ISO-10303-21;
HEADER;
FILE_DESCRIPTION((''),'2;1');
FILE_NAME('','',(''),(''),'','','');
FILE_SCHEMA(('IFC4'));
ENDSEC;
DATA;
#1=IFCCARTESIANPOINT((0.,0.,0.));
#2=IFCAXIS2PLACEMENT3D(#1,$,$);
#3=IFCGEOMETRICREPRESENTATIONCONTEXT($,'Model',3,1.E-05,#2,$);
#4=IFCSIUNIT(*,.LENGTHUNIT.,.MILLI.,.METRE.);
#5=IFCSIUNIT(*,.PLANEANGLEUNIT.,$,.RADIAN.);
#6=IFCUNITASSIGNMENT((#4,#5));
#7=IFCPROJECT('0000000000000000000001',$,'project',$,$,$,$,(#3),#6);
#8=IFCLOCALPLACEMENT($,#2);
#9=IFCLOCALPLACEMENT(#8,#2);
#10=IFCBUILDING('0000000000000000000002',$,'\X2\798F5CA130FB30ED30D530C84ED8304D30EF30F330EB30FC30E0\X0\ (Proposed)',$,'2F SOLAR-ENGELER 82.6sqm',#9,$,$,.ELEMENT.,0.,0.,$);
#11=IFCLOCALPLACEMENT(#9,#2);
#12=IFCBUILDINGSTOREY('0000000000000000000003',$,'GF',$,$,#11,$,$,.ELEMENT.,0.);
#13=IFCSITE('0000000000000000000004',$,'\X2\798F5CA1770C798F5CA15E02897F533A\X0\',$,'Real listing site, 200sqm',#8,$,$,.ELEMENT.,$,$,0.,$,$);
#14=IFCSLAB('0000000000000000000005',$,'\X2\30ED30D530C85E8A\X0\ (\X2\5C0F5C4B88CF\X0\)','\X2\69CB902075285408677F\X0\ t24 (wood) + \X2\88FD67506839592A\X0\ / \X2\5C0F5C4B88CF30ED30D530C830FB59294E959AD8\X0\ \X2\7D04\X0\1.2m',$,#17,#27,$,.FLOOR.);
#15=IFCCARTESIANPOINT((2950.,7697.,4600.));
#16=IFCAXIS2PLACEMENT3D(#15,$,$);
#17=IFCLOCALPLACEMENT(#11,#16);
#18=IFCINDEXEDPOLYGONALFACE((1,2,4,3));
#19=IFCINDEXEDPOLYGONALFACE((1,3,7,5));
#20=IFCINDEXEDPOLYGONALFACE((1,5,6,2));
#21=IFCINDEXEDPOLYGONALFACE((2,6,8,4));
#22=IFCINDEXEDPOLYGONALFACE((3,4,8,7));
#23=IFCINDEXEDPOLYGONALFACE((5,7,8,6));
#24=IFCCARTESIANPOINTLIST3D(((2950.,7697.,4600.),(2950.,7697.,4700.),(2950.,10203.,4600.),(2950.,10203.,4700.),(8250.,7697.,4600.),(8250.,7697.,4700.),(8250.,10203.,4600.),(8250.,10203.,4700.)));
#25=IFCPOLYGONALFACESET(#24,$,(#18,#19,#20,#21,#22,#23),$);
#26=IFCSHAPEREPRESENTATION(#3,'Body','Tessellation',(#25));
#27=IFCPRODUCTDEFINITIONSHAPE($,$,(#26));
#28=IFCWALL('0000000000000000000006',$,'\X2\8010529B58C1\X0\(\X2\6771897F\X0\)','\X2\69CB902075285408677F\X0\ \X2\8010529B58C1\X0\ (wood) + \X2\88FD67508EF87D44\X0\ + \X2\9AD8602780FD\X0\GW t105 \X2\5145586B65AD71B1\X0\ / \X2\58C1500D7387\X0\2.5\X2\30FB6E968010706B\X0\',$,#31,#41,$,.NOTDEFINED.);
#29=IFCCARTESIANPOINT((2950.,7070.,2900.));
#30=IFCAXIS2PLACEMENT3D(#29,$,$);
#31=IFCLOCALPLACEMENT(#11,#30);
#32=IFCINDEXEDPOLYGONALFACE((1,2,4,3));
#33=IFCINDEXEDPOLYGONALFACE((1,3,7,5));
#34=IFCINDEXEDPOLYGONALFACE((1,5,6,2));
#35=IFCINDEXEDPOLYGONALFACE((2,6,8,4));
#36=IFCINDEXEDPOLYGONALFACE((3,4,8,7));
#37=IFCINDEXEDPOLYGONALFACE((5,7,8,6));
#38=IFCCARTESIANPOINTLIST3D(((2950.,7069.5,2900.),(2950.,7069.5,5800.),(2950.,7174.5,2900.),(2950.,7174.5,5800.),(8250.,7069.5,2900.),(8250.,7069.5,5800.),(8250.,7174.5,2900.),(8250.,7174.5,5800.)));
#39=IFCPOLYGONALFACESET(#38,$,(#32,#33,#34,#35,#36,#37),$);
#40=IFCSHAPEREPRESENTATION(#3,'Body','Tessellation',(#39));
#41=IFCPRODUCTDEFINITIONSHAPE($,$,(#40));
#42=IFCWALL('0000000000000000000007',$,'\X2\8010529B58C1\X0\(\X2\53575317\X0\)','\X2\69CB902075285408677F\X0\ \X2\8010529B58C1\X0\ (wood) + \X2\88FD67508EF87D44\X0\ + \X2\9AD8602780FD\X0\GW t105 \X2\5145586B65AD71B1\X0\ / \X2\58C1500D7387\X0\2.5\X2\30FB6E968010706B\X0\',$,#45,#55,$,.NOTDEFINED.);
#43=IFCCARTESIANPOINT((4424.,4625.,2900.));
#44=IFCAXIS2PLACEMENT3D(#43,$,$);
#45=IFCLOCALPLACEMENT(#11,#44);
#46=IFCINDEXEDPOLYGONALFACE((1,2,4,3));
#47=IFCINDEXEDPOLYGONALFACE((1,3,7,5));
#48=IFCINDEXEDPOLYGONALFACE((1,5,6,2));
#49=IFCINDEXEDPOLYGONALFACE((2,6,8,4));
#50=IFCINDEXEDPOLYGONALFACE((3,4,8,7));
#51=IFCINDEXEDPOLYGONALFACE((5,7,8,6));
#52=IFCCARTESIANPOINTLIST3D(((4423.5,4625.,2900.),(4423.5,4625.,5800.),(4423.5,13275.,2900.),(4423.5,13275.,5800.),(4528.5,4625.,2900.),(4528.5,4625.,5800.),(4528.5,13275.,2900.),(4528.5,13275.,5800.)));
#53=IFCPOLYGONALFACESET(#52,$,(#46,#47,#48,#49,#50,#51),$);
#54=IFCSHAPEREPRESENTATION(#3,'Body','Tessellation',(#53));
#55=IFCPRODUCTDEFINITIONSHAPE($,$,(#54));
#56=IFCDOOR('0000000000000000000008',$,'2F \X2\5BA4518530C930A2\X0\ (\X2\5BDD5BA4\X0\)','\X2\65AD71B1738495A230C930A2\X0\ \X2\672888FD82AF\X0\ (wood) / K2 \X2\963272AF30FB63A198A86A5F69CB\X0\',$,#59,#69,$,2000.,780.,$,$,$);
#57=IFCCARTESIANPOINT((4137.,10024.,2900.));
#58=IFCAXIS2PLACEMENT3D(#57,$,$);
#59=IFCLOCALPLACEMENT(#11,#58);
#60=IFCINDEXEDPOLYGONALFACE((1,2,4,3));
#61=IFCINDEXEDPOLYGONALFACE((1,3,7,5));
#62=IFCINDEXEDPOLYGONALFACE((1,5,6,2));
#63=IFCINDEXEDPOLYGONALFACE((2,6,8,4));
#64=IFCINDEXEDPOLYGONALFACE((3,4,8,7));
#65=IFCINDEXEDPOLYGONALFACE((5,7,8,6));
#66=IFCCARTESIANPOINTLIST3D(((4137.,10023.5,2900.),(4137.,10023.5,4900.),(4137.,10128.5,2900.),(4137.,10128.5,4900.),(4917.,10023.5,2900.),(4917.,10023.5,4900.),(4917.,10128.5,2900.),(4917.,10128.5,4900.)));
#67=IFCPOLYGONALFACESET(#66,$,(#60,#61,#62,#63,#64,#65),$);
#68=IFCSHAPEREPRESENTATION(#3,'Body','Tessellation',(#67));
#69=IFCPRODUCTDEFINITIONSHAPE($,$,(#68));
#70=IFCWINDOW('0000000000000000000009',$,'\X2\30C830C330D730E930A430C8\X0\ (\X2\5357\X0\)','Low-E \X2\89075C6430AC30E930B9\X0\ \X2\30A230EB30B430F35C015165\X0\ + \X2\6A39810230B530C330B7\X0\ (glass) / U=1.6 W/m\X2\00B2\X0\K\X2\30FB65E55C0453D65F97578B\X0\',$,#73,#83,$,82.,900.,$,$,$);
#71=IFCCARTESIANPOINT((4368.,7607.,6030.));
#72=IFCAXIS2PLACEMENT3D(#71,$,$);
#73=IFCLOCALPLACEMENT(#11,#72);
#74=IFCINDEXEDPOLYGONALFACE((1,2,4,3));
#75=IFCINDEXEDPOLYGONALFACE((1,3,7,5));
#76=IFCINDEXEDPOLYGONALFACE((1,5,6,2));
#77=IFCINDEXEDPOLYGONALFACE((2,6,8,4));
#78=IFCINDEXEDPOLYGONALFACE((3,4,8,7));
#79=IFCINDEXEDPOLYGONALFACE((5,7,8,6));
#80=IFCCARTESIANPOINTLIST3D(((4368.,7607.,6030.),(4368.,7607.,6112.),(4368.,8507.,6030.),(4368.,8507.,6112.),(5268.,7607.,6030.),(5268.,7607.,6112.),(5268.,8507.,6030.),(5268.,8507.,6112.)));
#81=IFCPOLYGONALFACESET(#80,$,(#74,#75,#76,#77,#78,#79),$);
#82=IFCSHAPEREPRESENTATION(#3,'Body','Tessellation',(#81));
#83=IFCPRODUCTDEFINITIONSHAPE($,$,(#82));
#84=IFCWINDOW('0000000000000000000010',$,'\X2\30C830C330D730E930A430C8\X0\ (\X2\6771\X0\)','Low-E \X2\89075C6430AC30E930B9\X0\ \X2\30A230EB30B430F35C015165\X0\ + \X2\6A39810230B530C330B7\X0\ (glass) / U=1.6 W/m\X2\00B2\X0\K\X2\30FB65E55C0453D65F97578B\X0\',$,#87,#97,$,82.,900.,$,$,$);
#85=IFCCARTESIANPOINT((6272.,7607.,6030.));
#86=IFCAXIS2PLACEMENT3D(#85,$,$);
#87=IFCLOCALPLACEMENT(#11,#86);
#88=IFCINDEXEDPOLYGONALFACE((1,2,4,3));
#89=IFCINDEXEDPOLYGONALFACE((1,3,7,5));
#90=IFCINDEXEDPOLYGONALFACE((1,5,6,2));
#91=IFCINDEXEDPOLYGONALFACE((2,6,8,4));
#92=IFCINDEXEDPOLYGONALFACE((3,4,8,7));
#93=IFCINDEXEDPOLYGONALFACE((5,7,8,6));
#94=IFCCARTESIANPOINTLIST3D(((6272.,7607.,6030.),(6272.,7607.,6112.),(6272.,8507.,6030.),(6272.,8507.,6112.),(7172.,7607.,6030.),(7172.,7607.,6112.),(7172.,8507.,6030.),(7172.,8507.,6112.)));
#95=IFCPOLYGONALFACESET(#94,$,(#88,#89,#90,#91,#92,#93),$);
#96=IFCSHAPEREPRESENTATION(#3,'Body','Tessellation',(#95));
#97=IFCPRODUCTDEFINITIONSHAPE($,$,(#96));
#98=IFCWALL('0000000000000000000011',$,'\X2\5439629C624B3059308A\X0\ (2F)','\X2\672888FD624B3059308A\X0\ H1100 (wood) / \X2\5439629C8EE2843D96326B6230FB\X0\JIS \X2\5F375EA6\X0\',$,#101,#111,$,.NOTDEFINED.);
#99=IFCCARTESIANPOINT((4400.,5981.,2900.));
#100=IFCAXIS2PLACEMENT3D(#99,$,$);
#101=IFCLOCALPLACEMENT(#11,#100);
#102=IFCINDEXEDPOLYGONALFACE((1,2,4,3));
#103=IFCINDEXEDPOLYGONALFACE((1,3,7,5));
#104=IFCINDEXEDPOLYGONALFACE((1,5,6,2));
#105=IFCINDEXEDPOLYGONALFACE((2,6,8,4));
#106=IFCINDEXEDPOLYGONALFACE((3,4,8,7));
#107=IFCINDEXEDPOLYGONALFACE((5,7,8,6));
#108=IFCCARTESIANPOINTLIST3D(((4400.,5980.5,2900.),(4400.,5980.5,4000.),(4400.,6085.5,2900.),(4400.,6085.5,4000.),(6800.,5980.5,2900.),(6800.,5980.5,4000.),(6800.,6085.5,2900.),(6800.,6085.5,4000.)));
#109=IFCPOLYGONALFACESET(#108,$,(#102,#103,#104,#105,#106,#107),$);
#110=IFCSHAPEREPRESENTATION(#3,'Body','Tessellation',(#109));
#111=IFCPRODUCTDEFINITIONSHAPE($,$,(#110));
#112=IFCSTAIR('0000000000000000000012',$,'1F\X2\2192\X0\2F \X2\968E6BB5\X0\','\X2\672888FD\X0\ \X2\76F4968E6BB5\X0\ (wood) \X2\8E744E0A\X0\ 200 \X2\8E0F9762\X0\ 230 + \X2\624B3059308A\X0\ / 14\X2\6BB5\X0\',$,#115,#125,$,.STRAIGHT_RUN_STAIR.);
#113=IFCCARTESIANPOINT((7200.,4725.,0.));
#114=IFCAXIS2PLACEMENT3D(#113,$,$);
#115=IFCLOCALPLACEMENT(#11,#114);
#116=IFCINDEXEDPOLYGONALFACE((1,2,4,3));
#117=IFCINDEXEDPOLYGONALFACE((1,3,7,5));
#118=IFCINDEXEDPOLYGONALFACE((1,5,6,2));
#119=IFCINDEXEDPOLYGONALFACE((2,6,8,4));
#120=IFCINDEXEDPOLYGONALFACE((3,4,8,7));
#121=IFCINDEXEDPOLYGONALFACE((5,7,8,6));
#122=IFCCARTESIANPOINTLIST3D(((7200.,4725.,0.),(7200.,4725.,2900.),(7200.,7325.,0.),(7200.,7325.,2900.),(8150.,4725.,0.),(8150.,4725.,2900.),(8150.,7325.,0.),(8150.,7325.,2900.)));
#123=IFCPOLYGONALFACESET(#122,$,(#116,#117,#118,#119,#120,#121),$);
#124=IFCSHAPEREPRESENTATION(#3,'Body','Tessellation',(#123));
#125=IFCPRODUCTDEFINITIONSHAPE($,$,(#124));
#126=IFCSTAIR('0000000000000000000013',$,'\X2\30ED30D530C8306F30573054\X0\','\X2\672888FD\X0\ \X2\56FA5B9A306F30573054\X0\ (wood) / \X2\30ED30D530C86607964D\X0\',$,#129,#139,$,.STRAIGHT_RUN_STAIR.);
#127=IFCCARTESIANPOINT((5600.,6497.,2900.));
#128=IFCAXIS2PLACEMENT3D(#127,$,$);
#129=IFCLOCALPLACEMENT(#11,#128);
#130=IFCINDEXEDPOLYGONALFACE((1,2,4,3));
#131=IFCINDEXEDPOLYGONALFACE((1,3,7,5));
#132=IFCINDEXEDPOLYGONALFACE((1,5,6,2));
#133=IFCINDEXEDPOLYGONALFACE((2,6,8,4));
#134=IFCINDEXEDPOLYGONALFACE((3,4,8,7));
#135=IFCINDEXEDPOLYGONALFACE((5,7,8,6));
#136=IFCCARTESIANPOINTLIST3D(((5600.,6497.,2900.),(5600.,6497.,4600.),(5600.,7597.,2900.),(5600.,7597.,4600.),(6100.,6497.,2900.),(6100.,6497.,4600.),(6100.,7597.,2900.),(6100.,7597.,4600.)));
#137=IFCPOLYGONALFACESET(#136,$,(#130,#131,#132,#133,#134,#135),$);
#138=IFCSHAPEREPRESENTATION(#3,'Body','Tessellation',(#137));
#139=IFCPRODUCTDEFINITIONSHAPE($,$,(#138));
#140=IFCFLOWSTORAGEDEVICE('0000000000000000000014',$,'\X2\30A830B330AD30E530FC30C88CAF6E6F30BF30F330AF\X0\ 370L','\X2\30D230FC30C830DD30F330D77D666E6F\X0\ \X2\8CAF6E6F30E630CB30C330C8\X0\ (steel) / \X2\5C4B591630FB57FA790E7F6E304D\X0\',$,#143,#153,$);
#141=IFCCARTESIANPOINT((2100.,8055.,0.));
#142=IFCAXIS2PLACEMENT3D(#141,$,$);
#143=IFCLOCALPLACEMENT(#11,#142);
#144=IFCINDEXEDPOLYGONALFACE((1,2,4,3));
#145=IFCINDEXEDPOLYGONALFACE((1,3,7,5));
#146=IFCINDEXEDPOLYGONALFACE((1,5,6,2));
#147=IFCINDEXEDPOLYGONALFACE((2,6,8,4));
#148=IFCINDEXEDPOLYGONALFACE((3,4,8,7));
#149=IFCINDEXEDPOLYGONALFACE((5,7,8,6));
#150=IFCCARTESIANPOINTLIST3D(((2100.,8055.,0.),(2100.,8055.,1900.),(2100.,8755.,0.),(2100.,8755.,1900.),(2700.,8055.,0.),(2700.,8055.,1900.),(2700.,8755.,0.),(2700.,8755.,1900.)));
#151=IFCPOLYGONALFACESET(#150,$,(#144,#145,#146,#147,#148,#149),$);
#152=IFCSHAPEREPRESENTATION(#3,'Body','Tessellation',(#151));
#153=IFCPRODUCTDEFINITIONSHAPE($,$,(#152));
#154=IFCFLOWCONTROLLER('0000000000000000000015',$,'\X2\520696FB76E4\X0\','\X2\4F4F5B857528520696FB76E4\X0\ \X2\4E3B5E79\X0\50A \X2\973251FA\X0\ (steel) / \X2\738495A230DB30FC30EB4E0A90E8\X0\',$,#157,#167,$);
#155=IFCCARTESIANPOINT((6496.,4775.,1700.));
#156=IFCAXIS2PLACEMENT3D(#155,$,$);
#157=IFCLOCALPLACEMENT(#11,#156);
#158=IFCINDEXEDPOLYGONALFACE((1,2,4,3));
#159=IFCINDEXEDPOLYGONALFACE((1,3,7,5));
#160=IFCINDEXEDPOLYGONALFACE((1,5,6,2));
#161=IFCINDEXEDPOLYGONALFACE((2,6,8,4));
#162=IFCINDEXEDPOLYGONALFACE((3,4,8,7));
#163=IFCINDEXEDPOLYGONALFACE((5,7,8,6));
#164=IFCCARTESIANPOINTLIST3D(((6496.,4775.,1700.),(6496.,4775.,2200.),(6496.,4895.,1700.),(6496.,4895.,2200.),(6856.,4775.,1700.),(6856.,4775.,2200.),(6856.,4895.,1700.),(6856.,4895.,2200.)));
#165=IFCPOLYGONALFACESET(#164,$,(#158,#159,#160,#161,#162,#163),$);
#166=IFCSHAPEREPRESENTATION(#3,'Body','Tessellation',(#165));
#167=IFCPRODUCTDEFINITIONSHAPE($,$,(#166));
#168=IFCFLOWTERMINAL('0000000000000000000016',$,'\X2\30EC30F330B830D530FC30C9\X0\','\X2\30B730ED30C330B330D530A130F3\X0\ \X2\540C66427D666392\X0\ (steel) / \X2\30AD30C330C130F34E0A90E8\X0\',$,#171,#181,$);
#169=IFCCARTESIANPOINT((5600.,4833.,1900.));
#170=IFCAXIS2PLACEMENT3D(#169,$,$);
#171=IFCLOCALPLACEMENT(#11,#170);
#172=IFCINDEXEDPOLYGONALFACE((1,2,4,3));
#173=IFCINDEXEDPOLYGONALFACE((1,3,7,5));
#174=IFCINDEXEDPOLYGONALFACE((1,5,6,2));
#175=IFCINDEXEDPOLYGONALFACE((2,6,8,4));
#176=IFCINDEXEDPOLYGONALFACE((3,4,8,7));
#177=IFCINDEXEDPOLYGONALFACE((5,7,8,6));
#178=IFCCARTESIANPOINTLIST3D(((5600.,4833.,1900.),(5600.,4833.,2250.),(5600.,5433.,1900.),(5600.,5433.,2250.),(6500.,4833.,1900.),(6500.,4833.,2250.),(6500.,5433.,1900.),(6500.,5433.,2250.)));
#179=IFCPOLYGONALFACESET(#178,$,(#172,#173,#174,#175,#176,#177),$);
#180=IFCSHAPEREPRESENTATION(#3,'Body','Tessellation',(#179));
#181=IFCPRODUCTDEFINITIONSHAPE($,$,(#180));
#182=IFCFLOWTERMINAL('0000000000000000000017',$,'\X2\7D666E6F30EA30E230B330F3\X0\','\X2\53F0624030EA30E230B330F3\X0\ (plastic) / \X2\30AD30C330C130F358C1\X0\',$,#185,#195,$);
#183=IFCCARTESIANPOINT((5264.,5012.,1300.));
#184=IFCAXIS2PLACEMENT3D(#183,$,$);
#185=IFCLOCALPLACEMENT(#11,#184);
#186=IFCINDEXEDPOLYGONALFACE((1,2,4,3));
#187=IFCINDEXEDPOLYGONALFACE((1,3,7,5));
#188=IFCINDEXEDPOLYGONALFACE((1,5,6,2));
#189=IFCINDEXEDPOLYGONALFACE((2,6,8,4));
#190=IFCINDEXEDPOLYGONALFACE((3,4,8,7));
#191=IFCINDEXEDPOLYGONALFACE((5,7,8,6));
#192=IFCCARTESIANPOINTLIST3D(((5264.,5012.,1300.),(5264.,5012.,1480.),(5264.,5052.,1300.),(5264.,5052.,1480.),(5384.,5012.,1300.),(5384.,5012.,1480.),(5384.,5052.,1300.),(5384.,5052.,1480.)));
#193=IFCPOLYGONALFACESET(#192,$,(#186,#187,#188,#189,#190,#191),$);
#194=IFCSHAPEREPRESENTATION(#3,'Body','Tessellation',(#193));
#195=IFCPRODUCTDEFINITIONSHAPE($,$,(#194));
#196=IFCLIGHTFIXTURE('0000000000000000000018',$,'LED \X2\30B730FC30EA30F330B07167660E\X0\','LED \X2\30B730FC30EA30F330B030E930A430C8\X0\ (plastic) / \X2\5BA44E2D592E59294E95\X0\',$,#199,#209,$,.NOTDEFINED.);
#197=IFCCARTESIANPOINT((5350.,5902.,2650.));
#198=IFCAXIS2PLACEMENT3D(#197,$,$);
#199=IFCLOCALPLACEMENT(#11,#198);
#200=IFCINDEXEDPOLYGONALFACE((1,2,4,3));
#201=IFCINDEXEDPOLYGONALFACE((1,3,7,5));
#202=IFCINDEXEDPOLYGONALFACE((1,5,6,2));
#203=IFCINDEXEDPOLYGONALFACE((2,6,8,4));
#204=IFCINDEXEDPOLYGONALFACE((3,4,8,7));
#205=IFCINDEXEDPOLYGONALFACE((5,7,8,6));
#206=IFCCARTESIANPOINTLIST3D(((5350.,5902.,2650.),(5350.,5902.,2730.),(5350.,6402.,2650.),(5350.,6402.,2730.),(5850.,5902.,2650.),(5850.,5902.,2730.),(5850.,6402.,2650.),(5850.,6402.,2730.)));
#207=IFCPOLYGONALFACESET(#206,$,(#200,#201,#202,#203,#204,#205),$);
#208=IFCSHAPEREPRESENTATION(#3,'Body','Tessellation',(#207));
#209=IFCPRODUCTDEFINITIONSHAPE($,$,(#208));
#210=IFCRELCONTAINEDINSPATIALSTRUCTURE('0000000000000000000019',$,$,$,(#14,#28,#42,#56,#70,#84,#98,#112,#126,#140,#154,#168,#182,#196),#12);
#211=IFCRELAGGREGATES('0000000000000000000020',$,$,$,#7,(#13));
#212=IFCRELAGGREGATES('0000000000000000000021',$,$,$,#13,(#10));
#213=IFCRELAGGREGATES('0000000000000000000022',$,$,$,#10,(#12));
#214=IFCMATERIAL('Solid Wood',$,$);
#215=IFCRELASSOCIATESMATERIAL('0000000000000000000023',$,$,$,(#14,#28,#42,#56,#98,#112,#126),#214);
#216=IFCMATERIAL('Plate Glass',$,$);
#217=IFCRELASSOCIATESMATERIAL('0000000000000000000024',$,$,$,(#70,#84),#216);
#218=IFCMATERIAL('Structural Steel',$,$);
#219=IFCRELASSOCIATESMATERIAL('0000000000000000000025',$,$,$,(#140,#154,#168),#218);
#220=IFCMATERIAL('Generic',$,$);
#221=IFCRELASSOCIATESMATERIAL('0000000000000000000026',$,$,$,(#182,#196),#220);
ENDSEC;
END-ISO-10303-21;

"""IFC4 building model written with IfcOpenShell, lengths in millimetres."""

from ifc_helpers import new_model, si_unit, frame, frame_2d, origin, place, context, project, spatial, rectangle, extrude, material, element, fill, save


model = new_model("IFC4")

# Units and contexts
model_context = context("Model", 3, precision=1e-05, world=origin())
ifc_project = project(units=[si_unit("LENGTHUNIT", "METRE", prefix="MILLI"), si_unit("PLANEANGLEUNIT", "RADIAN")], contexts=[model_context])

# Site, building, storey
site_placement = place(None, origin())
site = spatial("IfcSite", under=ifc_project, at=site_placement, Name="福岡県福岡市西区", ObjectType="Real listing site, 200sqm", CompositionType="ELEMENT", RefElevation=0.0)
building_placement = place(site_placement, origin())
building = spatial("IfcBuilding", under=site, at=building_placement, Name="福岡・ロフト付きワンルーム (Proposed)", ObjectType="2F SOLAR-ENGELER 82.6sqm", CompositionType="ELEMENT", ElevationOfRefHeight=0.0, ElevationOfTerrain=0.0)
storey_placement = place(building_placement, origin())
storey = spatial("IfcBuildingStorey", under=building, at=storey_placement, Name="GF", CompositionType="ELEMENT", Elevation=0.0)

# Shared definitions
ifc_material_1 = material(Name="Solid Wood")

# Slab
slab_placement = place(storey_placement, frame((2950.0, 7697.0, 4600.0)))
element("IfcSlab", 1, at=slab_placement, inside=storey, material=ifc_material_1, Name="ロフト床 (小屋裏)", Description="構造用合板 t24 (wood) + 製材根太 / 小屋裏ロフト・天井高 約1.2m", PredefinedType="FLOOR", context=model_context, shape_type="SweptSolid", body=[
    extrude(rectangle(XDim=5300.0, YDim=2506.0, at=frame_2d((2650.0, 1253.0))), frame((2950.0, 7697.0, 4600.0)), (0.0, 0.0, 1.0), 100.0),
])

# Wall
wall_1_placement = place(storey_placement, frame((2950.0, 7070.0, 2900.0)))
element("IfcWall", 2, at=wall_1_placement, inside=storey, material=ifc_material_1, Name="耐力壁(東西)", Description="構造用合板 耐力壁 (wood) + 製材軸組 + 高性能GW t105 充填断熱 / 壁倍率2.5・準耐火", PredefinedType="NOTDEFINED", context=model_context, shape_type="SweptSolid", body=[
    extrude(rectangle(XDim=5300.0, YDim=105.0, at=frame_2d((2650.0, 52.0))), frame((2950.0, 7070.0, 2900.0)), (0.0, 0.0, 1.0), 2900.0),
])

# Wall, opening, door
wall_2_placement = place(storey_placement, frame((4424.0, 4625.0, 2900.0)))
wall_2 = element("IfcWall", 3, at=wall_2_placement, inside=storey, material=ifc_material_1, Name="耐力壁(南北)", Description="構造用合板 耐力壁 (wood) + 製材軸組 + 高性能GW t105 充填断熱 / 壁倍率2.5・準耐火", PredefinedType="NOTDEFINED", context=model_context, shape_type="SweptSolid", body=[
    extrude(rectangle(XDim=105.0, YDim=8650.0, at=frame_2d((52.0, 4325.0))), frame((4424.0, 4625.0, 2900.0)), (0.0, 0.0, 1.0), 2900.0),
])
opening_placement = place(storey_placement, frame((4137.0, 10024.0, 2900.0)))
opening = element("IfcOpeningElement", 4, at=opening_placement, cuts=wall_2, PredefinedType="NOTDEFINED", context=model_context, shape_type="SweptSolid", body=[
    extrude(rectangle(XDim=780.0, YDim=105.0, at=frame_2d((390.0, 52.0))), frame((4137.0, 10024.0, 2900.0)), (0.0, 0.0, 1.0), 2000.0),
])
door_placement = place(storey_placement, frame((4137.0, 10024.0, 2900.0)))
door = element("IfcDoor", 5, at=door_placement, inside=storey, material=ifc_material_1, Name="2F 室内ドア (寝室)", Description="断熱玄関ドア 木製芯 (wood) / K2 防犯・採風機構", OverallHeight=2000.0, OverallWidth=780.0, context=model_context, shape_type="SweptSolid", body=[
    extrude(rectangle(XDim=780.0, YDim=105.0, at=frame_2d((390.0, 52.0))), frame((4137.0, 10024.0, 2900.0)), (0.0, 0.0, 1.0), 2000.0),
])
fill(opening, door)

# Windows
ifc_material_2 = material(Name="Plate Glass")
window_1_placement = place(storey_placement, frame((4368.0, 7607.0, 6030.0)))
element("IfcWindow", 6, at=window_1_placement, inside=storey, material=ifc_material_2, Name="トップライト (南)", Description="Low-E 複層ガラス アルゴン封入 + 樹脂サッシ (glass) / U=1.6 W/m²K・日射取得型", OverallHeight=82.0, OverallWidth=900.0, context=model_context, shape_type="SweptSolid", body=[
    extrude(rectangle(XDim=900.0, YDim=900.0, at=frame_2d((450.0, 450.0))), frame((4368.0, 7607.0, 6030.0)), (0.0, 0.0, 1.0), 82.0),
])
window_2_placement = place(storey_placement, frame((6272.0, 7607.0, 6030.0)))
element("IfcWindow", 7, at=window_2_placement, inside=storey, material=ifc_material_2, Name="トップライト (東)", Description="Low-E 複層ガラス アルゴン封入 + 樹脂サッシ (glass) / U=1.6 W/m²K・日射取得型", OverallHeight=82.0, OverallWidth=900.0, context=model_context, shape_type="SweptSolid", body=[
    extrude(rectangle(XDim=900.0, YDim=900.0, at=frame_2d((450.0, 450.0))), frame((6272.0, 7607.0, 6030.0)), (0.0, 0.0, 1.0), 82.0),
])

# Wall
wall_3_placement = place(storey_placement, frame((4400.0, 5981.0, 2900.0)))
element("IfcWall", 8, at=wall_3_placement, inside=storey, material=ifc_material_1, Name="吹抜手すり (2F)", Description="木製手すり H1100 (wood) / 吹抜転落防止・JIS 強度", PredefinedType="NOTDEFINED", context=model_context, shape_type="SweptSolid", body=[
    extrude(rectangle(XDim=2400.0, YDim=105.0, at=frame_2d((1200.0, 52.0))), frame((4400.0, 5981.0, 2900.0)), (0.0, 0.0, 1.0), 1100.0),
])

# Stairs
stair_1_placement = place(storey_placement, frame((7200.0, 4725.0, 0.0)))
element("IfcStair", 9, at=stair_1_placement, inside=storey, material=ifc_material_1, Name="1F→2F 階段", Description="木製 直階段 (wood) 蹴上 200 踏面 230 + 手すり / 14段", PredefinedType="STRAIGHT_RUN_STAIR", context=model_context, shape_type="SweptSolid", body=[
    extrude(rectangle(XDim=950.0, YDim=2600.0, at=frame_2d((475.0, 1300.0))), frame((7200.0, 4725.0, 0.0)), (0.0, 0.0, 1.0), 2900.0),
])
stair_2_placement = place(storey_placement, frame((5600.0, 6497.0, 2900.0)))
element("IfcStair", 10, at=stair_2_placement, inside=storey, material=ifc_material_1, Name="ロフトはしご", Description="木製 固定はしご (wood) / ロフト昇降", PredefinedType="STRAIGHT_RUN_STAIR", context=model_context, shape_type="SweptSolid", body=[
    extrude(rectangle(XDim=500.0, YDim=1100.0, at=frame_2d((250.0, 550.0))), frame((5600.0, 6497.0, 2900.0)), (0.0, 0.0, 1.0), 1700.0),
])

# Flow storage device
ifc_material_3 = material(Name="Structural Steel")
flow_storage_device_placement = place(storey_placement, frame((2100.0, 8055.0, 0.0)))
element("IfcFlowStorageDevice", 11, at=flow_storage_device_placement, inside=storey, material=ifc_material_3, Name="エコキュート貯湯タンク 370L", Description="ヒートポンプ給湯 貯湯ユニット (steel) / 屋外・基礎置き", context=model_context, shape_type="SweptSolid", body=[
    extrude(rectangle(XDim=600.0, YDim=700.0, at=frame_2d((300.0, 350.0))), frame((2100.0, 8055.0, 0.0)), (0.0, 0.0, 1.0), 1900.0),
])

# Flow controller
flow_controller_placement = place(storey_placement, frame((6496.0, 4775.0, 1700.0)))
element("IfcFlowController", 12, at=flow_controller_placement, inside=storey, material=ifc_material_3, Name="分電盤", Description="住宅用分電盤 主幹50A 露出 (steel) / 玄関ホール上部", context=model_context, shape_type="SweptSolid", body=[
    extrude(rectangle(XDim=360.0, YDim=120.0, at=frame_2d((180.0, 60.0))), frame((6496.0, 4775.0, 1700.0)), (0.0, 0.0, 1.0), 500.0),
])

# Flow terminals
flow_terminal_1_placement = place(storey_placement, frame((5600.0, 4833.0, 1900.0)))
element("IfcFlowTerminal", 13, at=flow_terminal_1_placement, inside=storey, material=ifc_material_3, Name="レンジフード", Description="シロッコファン 同時給排 (steel) / キッチン上部", context=model_context, shape_type="SweptSolid", body=[
    extrude(rectangle(XDim=900.0, YDim=600.0, at=frame_2d((450.0, 300.0))), frame((5600.0, 4833.0, 1900.0)), (0.0, 0.0, 1.0), 350.0),
])
ifc_material_4 = material(Name="Generic")
flow_terminal_2_placement = place(storey_placement, frame((5264.0, 5012.0, 1300.0)))
element("IfcFlowTerminal", 14, at=flow_terminal_2_placement, inside=storey, material=ifc_material_4, Name="給湯リモコン", Description="台所リモコン (plastic) / キッチン壁", context=model_context, shape_type="SweptSolid", body=[
    extrude(rectangle(XDim=120.0, YDim=40.0, at=frame_2d((60.0, 20.0))), frame((5264.0, 5012.0, 1300.0)), (0.0, 0.0, 1.0), 180.0),
])

# Light fixture
light_fixture_1_placement = place(storey_placement, frame((5350.0, 5902.0, 2650.0)))
element("IfcLightFixture", 15, at=light_fixture_1_placement, inside=storey, material=ifc_material_4, Name="LED シーリング照明", Description="LED シーリングライト (plastic) / 室中央天井", PredefinedType="NOTDEFINED", context=model_context, shape_type="SweptSolid", body=[
    extrude(rectangle(XDim=500.0, YDim=500.0, at=frame_2d((250.0, 250.0))), frame((5350.0, 5902.0, 2650.0)), (0.0, 0.0, 1.0), 80.0),
])

save(model, "model.ifc")
